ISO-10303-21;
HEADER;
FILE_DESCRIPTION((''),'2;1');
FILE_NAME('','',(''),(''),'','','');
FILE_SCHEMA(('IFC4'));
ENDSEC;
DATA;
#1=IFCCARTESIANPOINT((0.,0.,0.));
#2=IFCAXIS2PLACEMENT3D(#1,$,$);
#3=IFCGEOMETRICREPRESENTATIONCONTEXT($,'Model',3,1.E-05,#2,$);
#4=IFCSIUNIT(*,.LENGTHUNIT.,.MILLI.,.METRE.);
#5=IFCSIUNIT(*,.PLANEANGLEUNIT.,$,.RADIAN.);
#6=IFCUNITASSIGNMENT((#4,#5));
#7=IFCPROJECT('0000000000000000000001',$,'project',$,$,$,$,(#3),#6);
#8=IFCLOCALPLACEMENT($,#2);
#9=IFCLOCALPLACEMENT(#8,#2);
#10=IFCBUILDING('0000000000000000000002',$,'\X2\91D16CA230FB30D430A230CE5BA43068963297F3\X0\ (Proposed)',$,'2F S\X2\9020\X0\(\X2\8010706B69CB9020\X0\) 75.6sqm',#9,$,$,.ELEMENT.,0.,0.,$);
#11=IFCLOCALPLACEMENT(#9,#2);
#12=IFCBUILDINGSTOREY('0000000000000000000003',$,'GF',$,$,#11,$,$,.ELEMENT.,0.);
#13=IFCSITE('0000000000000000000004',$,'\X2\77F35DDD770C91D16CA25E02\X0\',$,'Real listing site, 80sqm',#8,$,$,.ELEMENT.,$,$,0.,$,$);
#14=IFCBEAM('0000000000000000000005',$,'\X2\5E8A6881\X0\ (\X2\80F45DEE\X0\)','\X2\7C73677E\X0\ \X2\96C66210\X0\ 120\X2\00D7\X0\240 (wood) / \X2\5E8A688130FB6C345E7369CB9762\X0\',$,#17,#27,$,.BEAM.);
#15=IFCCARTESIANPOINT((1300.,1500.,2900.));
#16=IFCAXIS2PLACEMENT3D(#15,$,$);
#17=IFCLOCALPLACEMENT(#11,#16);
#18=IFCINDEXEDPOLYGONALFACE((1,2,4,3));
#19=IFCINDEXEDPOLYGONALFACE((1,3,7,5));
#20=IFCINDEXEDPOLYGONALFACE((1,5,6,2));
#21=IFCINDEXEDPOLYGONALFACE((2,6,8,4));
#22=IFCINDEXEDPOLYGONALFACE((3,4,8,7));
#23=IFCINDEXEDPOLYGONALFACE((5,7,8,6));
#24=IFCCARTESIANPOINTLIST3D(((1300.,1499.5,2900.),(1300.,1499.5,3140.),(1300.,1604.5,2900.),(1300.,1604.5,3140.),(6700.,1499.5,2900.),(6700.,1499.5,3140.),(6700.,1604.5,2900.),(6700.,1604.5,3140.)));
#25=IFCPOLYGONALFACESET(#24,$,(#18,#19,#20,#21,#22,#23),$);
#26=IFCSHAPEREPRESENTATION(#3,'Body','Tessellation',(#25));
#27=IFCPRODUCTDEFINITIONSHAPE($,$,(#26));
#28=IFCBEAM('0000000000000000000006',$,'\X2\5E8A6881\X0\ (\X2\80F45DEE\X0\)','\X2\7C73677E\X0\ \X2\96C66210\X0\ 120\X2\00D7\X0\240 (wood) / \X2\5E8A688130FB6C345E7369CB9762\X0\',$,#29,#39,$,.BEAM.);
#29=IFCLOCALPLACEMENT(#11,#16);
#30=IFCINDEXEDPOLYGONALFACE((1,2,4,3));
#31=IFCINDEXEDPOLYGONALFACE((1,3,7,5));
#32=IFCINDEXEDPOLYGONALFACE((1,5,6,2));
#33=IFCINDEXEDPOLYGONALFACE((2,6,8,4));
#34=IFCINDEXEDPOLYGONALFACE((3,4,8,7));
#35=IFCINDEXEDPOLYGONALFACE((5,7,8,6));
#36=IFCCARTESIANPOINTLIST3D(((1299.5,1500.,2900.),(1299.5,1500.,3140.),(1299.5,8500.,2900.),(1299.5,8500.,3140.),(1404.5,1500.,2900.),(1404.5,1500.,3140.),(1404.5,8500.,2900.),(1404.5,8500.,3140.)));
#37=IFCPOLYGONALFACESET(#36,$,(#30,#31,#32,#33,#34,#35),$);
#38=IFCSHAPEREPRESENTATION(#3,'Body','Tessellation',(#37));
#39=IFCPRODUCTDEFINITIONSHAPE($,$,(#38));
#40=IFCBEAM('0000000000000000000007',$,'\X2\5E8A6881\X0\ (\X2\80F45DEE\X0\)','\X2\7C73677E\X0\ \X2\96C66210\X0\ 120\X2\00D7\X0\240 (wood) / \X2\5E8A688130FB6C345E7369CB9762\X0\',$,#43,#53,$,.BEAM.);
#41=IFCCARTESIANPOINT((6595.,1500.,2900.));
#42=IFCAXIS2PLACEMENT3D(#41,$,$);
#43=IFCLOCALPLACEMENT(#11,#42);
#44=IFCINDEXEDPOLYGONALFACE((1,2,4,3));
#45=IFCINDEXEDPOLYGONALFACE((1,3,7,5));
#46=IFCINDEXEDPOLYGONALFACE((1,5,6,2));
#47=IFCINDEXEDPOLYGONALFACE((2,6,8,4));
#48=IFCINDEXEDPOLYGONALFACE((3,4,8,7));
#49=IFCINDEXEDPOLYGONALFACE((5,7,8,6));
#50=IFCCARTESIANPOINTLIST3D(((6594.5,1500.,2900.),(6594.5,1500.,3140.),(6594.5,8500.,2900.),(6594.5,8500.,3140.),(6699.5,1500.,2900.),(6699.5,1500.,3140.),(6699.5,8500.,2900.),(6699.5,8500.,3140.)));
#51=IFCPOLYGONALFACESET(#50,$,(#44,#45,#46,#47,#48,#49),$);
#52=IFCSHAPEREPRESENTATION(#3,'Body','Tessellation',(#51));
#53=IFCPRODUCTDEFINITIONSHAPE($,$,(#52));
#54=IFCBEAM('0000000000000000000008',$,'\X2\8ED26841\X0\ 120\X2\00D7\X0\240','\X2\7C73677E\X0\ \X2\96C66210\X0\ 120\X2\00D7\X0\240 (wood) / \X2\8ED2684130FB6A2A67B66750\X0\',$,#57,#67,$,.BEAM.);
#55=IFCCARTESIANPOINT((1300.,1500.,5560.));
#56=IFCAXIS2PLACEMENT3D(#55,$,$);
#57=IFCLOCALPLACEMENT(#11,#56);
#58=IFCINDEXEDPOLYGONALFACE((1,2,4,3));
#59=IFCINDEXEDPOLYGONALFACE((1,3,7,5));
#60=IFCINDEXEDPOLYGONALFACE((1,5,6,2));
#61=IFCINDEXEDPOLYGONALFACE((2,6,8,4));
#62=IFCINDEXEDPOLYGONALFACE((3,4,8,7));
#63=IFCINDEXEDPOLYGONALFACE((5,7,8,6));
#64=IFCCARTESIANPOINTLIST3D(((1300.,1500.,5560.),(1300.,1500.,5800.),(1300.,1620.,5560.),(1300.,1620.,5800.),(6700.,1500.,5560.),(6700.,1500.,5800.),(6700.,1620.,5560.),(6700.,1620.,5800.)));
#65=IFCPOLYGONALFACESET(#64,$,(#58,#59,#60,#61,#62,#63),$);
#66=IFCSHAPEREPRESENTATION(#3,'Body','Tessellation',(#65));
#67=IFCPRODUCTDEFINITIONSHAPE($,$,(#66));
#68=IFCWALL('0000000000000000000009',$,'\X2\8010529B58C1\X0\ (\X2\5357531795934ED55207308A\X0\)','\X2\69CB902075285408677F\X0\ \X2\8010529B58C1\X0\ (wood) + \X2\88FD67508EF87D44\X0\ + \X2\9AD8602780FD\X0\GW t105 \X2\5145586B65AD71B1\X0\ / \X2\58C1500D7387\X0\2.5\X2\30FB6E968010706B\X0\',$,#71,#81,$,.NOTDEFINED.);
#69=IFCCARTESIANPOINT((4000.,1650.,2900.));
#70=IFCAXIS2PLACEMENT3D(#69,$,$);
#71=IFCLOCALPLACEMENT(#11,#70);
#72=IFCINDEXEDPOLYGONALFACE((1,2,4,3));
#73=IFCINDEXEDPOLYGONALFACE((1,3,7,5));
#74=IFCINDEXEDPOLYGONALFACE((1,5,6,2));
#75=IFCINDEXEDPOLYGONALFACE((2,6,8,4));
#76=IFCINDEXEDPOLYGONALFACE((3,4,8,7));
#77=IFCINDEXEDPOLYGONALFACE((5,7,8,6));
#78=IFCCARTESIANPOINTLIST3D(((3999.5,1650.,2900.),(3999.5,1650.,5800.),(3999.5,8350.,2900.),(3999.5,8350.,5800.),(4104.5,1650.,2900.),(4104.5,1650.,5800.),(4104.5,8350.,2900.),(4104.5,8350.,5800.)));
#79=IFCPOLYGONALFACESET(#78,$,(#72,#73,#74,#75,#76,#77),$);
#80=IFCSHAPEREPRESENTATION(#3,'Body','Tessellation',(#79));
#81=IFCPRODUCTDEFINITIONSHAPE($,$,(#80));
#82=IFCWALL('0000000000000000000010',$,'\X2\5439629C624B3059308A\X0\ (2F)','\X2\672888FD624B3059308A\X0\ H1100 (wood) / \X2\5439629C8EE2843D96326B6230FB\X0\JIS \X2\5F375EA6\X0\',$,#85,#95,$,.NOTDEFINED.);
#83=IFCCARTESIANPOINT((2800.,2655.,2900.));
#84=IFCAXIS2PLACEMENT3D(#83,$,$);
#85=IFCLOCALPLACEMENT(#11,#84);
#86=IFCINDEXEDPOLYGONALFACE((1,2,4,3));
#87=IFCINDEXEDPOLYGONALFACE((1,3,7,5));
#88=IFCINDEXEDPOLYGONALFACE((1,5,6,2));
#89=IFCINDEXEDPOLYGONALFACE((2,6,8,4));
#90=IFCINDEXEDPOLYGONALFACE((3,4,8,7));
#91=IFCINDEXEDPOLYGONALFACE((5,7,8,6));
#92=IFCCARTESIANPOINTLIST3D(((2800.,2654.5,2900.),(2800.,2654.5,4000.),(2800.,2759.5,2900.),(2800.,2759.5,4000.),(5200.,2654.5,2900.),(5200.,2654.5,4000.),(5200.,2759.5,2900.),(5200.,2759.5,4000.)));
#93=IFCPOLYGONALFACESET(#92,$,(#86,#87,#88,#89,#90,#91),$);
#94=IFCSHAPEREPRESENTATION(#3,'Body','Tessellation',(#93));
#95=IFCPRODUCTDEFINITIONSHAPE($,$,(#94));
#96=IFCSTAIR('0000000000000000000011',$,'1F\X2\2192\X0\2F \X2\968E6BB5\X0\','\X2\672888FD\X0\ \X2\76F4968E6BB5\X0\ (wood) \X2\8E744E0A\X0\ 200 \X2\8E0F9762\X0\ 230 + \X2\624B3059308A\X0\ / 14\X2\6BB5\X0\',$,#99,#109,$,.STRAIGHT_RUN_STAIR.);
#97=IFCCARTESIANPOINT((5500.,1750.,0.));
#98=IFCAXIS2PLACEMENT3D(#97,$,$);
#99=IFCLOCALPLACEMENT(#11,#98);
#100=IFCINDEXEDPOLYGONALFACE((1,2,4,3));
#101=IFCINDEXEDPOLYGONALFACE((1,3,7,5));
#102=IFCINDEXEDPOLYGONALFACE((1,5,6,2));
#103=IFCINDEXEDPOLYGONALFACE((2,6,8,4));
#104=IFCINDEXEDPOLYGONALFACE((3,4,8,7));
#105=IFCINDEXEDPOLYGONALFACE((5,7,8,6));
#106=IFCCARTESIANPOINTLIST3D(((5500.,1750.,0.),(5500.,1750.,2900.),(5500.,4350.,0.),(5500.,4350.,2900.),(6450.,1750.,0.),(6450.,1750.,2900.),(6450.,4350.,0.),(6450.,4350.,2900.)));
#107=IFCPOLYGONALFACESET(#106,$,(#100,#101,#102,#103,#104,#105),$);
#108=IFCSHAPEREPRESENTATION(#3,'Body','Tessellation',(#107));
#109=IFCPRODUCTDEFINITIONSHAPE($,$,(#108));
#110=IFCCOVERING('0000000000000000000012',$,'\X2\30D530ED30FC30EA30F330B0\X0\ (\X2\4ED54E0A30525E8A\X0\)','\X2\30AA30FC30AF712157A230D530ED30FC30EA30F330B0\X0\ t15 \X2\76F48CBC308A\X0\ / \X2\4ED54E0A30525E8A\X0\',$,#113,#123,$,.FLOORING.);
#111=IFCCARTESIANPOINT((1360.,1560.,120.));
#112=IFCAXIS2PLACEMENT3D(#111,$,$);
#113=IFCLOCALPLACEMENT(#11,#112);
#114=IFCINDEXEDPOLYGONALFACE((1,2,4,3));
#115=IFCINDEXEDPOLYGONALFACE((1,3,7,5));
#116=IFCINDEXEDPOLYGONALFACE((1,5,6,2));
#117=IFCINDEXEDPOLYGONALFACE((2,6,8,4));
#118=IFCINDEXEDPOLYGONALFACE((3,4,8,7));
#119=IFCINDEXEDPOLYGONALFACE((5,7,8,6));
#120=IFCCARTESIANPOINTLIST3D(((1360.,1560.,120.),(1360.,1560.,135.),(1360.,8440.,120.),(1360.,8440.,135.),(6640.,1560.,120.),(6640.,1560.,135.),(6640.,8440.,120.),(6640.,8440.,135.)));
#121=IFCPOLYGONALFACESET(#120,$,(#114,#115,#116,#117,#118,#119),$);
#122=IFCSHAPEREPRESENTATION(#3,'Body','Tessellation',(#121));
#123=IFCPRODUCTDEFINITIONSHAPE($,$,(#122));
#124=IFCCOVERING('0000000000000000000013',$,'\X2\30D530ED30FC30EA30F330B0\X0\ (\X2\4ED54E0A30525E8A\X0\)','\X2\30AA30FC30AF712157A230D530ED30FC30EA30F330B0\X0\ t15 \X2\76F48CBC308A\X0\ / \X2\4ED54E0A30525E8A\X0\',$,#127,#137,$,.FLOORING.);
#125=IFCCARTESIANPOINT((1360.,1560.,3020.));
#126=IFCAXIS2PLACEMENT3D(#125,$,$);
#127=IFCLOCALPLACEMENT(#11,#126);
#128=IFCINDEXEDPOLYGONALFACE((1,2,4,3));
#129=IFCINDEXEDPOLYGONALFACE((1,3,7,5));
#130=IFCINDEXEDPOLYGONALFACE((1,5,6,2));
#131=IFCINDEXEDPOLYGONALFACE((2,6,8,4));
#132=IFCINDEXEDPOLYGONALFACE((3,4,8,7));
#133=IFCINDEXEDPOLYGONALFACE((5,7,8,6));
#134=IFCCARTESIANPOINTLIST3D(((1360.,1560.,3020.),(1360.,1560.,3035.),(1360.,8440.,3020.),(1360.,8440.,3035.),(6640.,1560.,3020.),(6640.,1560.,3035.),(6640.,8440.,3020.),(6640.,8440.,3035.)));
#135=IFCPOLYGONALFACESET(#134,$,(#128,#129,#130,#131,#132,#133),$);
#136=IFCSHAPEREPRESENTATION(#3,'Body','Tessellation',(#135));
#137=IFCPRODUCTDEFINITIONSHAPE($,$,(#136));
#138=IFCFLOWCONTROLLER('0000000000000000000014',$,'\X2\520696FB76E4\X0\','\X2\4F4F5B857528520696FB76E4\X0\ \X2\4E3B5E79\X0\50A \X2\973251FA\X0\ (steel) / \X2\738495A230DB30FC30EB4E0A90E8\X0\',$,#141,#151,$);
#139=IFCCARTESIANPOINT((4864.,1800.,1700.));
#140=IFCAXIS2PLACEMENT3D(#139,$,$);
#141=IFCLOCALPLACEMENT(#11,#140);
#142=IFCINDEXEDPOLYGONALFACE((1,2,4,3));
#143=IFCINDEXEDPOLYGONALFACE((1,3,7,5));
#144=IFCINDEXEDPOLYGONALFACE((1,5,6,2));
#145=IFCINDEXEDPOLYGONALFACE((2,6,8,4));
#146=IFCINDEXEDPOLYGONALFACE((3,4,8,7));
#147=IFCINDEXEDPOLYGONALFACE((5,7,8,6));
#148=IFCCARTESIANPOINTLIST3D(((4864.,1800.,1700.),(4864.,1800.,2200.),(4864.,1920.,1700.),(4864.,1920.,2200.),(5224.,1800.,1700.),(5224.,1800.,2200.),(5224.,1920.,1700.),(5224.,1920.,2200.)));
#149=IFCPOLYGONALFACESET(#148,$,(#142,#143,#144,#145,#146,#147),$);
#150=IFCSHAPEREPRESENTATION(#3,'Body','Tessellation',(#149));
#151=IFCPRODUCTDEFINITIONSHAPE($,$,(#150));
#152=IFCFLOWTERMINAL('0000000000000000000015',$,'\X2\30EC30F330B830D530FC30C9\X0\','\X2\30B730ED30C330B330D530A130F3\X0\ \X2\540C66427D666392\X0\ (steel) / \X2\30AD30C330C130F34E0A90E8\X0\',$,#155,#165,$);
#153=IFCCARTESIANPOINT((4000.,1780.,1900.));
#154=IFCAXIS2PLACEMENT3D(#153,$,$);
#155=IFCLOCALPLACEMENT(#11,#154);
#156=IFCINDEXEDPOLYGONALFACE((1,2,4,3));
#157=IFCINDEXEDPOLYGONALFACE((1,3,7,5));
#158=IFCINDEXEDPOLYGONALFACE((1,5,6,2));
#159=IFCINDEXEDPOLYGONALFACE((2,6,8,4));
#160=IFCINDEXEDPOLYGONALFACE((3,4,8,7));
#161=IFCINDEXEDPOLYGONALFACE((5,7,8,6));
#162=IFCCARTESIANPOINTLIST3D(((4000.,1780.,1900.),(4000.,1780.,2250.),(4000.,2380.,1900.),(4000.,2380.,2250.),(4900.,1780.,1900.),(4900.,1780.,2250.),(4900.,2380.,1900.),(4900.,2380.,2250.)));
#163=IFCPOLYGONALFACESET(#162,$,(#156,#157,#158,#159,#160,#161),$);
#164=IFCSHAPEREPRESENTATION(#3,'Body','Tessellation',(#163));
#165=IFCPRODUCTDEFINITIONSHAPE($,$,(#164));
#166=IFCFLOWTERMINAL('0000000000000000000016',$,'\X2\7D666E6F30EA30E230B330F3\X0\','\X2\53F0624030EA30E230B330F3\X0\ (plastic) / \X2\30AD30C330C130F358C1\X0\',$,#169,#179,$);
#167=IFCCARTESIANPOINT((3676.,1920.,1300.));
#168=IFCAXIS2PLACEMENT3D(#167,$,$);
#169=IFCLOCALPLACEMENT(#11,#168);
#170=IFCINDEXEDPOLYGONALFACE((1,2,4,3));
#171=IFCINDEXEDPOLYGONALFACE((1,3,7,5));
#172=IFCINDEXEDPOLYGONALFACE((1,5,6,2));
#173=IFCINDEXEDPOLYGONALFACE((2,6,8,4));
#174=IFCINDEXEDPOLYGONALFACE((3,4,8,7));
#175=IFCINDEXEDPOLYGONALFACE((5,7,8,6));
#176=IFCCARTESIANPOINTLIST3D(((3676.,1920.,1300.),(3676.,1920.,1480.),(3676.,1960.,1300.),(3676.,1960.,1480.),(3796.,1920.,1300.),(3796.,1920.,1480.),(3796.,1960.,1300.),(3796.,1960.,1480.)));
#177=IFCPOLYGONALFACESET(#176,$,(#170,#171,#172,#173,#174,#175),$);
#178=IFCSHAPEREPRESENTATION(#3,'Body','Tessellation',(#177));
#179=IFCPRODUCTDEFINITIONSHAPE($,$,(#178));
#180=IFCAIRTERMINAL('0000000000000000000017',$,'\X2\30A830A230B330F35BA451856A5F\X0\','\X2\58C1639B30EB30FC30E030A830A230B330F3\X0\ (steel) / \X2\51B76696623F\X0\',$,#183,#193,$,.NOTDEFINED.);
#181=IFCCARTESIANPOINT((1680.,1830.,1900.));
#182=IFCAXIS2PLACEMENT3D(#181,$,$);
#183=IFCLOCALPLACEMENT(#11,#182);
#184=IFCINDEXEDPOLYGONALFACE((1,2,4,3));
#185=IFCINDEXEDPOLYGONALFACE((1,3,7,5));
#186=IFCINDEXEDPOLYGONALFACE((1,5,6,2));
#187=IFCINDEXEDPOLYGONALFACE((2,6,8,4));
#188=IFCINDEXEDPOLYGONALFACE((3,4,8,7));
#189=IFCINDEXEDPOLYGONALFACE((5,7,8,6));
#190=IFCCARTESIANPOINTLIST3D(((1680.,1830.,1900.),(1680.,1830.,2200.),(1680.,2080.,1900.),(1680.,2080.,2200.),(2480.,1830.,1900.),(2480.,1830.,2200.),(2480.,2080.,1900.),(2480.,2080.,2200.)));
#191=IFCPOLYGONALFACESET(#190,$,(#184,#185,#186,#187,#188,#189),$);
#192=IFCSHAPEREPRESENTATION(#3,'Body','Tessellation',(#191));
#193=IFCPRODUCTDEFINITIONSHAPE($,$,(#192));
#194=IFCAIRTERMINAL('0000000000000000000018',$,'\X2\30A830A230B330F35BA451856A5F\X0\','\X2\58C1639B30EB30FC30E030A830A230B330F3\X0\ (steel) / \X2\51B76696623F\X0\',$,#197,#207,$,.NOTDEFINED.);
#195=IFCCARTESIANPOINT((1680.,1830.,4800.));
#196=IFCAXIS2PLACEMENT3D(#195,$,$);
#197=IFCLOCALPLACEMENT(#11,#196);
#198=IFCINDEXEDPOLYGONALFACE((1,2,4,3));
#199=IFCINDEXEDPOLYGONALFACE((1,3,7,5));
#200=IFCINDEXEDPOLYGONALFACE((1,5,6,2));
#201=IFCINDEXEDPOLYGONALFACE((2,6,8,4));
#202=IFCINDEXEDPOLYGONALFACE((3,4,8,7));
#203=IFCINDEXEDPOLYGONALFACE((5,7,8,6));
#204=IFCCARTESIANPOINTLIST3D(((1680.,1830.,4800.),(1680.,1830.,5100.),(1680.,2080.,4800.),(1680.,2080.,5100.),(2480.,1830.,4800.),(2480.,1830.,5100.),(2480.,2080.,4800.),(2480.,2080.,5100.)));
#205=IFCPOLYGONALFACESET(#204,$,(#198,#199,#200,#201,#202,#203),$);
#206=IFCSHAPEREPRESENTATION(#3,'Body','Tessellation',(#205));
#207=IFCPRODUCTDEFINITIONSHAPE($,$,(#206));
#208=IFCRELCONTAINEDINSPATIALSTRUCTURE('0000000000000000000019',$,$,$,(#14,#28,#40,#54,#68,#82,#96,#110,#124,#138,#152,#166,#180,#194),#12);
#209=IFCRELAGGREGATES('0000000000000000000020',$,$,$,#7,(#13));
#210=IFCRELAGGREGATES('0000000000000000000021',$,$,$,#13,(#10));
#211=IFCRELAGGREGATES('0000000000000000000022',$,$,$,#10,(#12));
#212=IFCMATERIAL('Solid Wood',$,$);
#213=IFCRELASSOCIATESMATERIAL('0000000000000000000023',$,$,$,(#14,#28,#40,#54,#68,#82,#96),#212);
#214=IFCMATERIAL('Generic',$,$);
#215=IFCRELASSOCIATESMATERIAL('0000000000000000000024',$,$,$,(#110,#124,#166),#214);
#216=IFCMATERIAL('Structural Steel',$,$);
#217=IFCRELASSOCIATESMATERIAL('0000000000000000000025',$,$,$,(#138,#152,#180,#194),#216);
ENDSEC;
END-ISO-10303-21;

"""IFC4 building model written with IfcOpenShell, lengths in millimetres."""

from ifc_helpers import new_model, si_unit, frame, frame_2d, origin, place, context, project, spatial, rectangle, extrude, material, element, save


model = new_model("IFC4")

# Units and contexts
model_context = context("Model", 3, precision=1e-05, world=origin())
ifc_project = project(units=[si_unit("LENGTHUNIT", "METRE", prefix="MILLI"), si_unit("PLANEANGLEUNIT", "RADIAN")], contexts=[model_context])

# Site, building, storey
site_placement = place(None, origin())
site = spatial("IfcSite", under=ifc_project, at=site_placement, Name="石川県金沢市", ObjectType="Real listing site, 80sqm", CompositionType="ELEMENT", RefElevation=0.0)
building_placement = place(site_placement, origin())
building = spatial("IfcBuilding", under=site, at=building_placement, Name="金沢・ピアノ室と防音 (Proposed)", ObjectType="2F S造(耐火構造) 75.6sqm", CompositionType="ELEMENT", ElevationOfRefHeight=0.0, ElevationOfTerrain=0.0)
storey_placement = place(building_placement, origin())
storey = spatial("IfcBuildingStorey", under=building, at=storey_placement, Name="GF", CompositionType="ELEMENT", Elevation=0.0)

# Shared definitions
ifc_material_1 = material(Name="Solid Wood")

# Beams
beam_1_placement = place(storey_placement, frame((1300.0, 1500.0, 2900.0)))
element("IfcBeam", 1, at=beam_1_placement, inside=storey, material=ifc_material_1, Name="床梁 (胴差)", Description="米松 集成 120×240 (wood) / 床梁・水平構面", PredefinedType="BEAM", context=model_context, shape_type="SweptSolid", body=[
    extrude(rectangle(XDim=5400.0, YDim=105.0, at=frame_2d((2700.0, 52.0))), frame((1300.0, 1500.0, 2900.0)), (0.0, 0.0, 1.0), 240.0),
])
beam_2_placement = place(storey_placement, frame((1300.0, 1500.0, 2900.0)))
element("IfcBeam", 2, at=beam_2_placement, inside=storey, material=ifc_material_1, Name="床梁 (胴差)", Description="米松 集成 120×240 (wood) / 床梁・水平構面", PredefinedType="BEAM", context=model_context, shape_type="SweptSolid", body=[
    extrude(rectangle(XDim=105.0, YDim=7000.0, at=frame_2d((52.0, 3500.0))), frame((1300.0, 1500.0, 2900.0)), (0.0, 0.0, 1.0), 240.0),
])
beam_3_placement = place(storey_placement, frame((6595.0, 1500.0, 2900.0)))
element("IfcBeam", 3, at=beam_3_placement, inside=storey, material=ifc_material_1, Name="床梁 (胴差)", Description="米松 集成 120×240 (wood) / 床梁・水平構面", PredefinedType="BEAM", context=model_context, shape_type="SweptSolid", body=[
    extrude(rectangle(XDim=105.0, YDim=7000.0, at=frame_2d((52.0, 3500.0))), frame((6595.0, 1500.0, 2900.0)), (0.0, 0.0, 1.0), 240.0),
])
beam_4_placement = place(storey_placement, frame((1300.0, 1500.0, 5560.0)))
element("IfcBeam", 4, at=beam_4_placement, inside=storey, material=ifc_material_1, Name="軒桁 120×240", Description="米松 集成 120×240 (wood) / 軒桁・横架材", PredefinedType="BEAM", context=model_context, shape_type="SweptSolid", body=[
    extrude(rectangle(XDim=5400.0, YDim=120.0, at=frame_2d((2700.0, 60.0))), frame((1300.0, 1500.0, 5560.0)), (0.0, 0.0, 1.0), 240.0),
])

# Walls
wall_1_placement = place(storey_placement, frame((4000.0, 1650.0, 2900.0)))
element("IfcWall", 5, at=wall_1_placement, inside=storey, material=ifc_material_1, Name="耐力壁 (南北間仕切り)", Description="構造用合板 耐力壁 (wood) + 製材軸組 + 高性能GW t105 充填断熱 / 壁倍率2.5・準耐火", PredefinedType="NOTDEFINED", context=model_context, shape_type="SweptSolid", body=[
    extrude(rectangle(XDim=105.0, YDim=6700.0, at=frame_2d((52.0, 3350.0))), frame((4000.0, 1650.0, 2900.0)), (0.0, 0.0, 1.0), 2900.0),
])
wall_2_placement = place(storey_placement, frame((2800.0, 2655.0, 2900.0)))
element("IfcWall", 6, at=wall_2_placement, inside=storey, material=ifc_material_1, Name="吹抜手すり (2F)", Description="木製手すり H1100 (wood) / 吹抜転落防止・JIS 強度", PredefinedType="NOTDEFINED", context=model_context, shape_type="SweptSolid", body=[
    extrude(rectangle(XDim=2400.0, YDim=105.0, at=frame_2d((1200.0, 52.0))), frame((2800.0, 2655.0, 2900.0)), (0.0, 0.0, 1.0), 1100.0),
])

# Stair
stair_placement = place(storey_placement, frame((5500.0, 1750.0, 0.0)))
element("IfcStair", 7, at=stair_placement, inside=storey, material=ifc_material_1, Name="1F→2F 階段", Description="木製 直階段 (wood) 蹴上 200 踏面 230 + 手すり / 14段", PredefinedType="STRAIGHT_RUN_STAIR", context=model_context, shape_type="SweptSolid", body=[
    extrude(rectangle(XDim=950.0, YDim=2600.0, at=frame_2d((475.0, 1300.0))), frame((5500.0, 1750.0, 0.0)), (0.0, 0.0, 1.0), 2900.0),
])

# Coverings
ifc_material_2 = material(Name="Generic")
covering_1_placement = place(storey_placement, frame((1360.0, 1560.0, 120.0)))
element("IfcCovering", 8, at=covering_1_placement, inside=storey, material=ifc_material_2, Name="フローリング (仕上げ床)", Description="オーク無垢フローリング t15 直貼り / 仕上げ床", PredefinedType="FLOORING", context=model_context, shape_type="SweptSolid", body=[
    extrude(rectangle(XDim=5280.0, YDim=6880.0, at=frame_2d((2640.0, 3440.0))), frame((1360.0, 1560.0, 120.0)), (0.0, 0.0, 1.0), 15.0),
])
covering_2_placement = place(storey_placement, frame((1360.0, 1560.0, 3020.0)))
element("IfcCovering", 9, at=covering_2_placement, inside=storey, material=ifc_material_2, Name="フローリング (仕上げ床)", Description="オーク無垢フローリング t15 直貼り / 仕上げ床", PredefinedType="FLOORING", context=model_context, shape_type="SweptSolid", body=[
    extrude(rectangle(XDim=5280.0, YDim=6880.0, at=frame_2d((2640.0, 3440.0))), frame((1360.0, 1560.0, 3020.0)), (0.0, 0.0, 1.0), 15.0),
])

# Flow controller
ifc_material_3 = material(Name="Structural Steel")
flow_controller_placement = place(storey_placement, frame((4864.0, 1800.0, 1700.0)))
element("IfcFlowController", 10, at=flow_controller_placement, inside=storey, material=ifc_material_3, Name="分電盤", Description="住宅用分電盤 主幹50A 露出 (steel) / 玄関ホール上部", context=model_context, shape_type="SweptSolid", body=[
    extrude(rectangle(XDim=360.0, YDim=120.0, at=frame_2d((180.0, 60.0))), frame((4864.0, 1800.0, 1700.0)), (0.0, 0.0, 1.0), 500.0),
])

# Flow terminals
flow_terminal_1_placement = place(storey_placement, frame((4000.0, 1780.0, 1900.0)))
element("IfcFlowTerminal", 11, at=flow_terminal_1_placement, inside=storey, material=ifc_material_3, Name="レンジフード", Description="シロッコファン 同時給排 (steel) / キッチン上部", context=model_context, shape_type="SweptSolid", body=[
    extrude(rectangle(XDim=900.0, YDim=600.0, at=frame_2d((450.0, 300.0))), frame((4000.0, 1780.0, 1900.0)), (0.0, 0.0, 1.0), 350.0),
])
flow_terminal_2_placement = place(storey_placement, frame((3676.0, 1920.0, 1300.0)))
element("IfcFlowTerminal", 12, at=flow_terminal_2_placement, inside=storey, material=ifc_material_2, Name="給湯リモコン", Description="台所リモコン (plastic) / キッチン壁", context=model_context, shape_type="SweptSolid", body=[
    extrude(rectangle(XDim=120.0, YDim=40.0, at=frame_2d((60.0, 20.0))), frame((3676.0, 1920.0, 1300.0)), (0.0, 0.0, 1.0), 180.0),
])

# Air terminals
air_terminal_1_placement = place(storey_placement, frame((1680.0, 1830.0, 1900.0)))
element("IfcAirTerminal", 13, at=air_terminal_1_placement, inside=storey, material=ifc_material_3, Name="エアコン室内機", Description="壁掛ルームエアコン (steel) / 冷暖房", PredefinedType="NOTDEFINED", context=model_context, shape_type="SweptSolid", body=[
    extrude(rectangle(XDim=800.0, YDim=250.0, at=frame_2d((400.0, 125.0))), frame((1680.0, 1830.0, 1900.0)), (0.0, 0.0, 1.0), 300.0),
])
air_terminal_2_placement = place(storey_placement, frame((1680.0, 1830.0, 4800.0)))
element("IfcAirTerminal", 14, at=air_terminal_2_placement, inside=storey, material=ifc_material_3, Name="エアコン室内機", Description="壁掛ルームエアコン (steel) / 冷暖房", PredefinedType="NOTDEFINED", context=model_context, shape_type="SweptSolid", body=[
    extrude(rectangle(XDim=800.0, YDim=250.0, at=frame_2d((400.0, 125.0))), frame((1680.0, 1830.0, 4800.0)), (0.0, 0.0, 1.0), 300.0),
])

save(model, "model.ifc")
